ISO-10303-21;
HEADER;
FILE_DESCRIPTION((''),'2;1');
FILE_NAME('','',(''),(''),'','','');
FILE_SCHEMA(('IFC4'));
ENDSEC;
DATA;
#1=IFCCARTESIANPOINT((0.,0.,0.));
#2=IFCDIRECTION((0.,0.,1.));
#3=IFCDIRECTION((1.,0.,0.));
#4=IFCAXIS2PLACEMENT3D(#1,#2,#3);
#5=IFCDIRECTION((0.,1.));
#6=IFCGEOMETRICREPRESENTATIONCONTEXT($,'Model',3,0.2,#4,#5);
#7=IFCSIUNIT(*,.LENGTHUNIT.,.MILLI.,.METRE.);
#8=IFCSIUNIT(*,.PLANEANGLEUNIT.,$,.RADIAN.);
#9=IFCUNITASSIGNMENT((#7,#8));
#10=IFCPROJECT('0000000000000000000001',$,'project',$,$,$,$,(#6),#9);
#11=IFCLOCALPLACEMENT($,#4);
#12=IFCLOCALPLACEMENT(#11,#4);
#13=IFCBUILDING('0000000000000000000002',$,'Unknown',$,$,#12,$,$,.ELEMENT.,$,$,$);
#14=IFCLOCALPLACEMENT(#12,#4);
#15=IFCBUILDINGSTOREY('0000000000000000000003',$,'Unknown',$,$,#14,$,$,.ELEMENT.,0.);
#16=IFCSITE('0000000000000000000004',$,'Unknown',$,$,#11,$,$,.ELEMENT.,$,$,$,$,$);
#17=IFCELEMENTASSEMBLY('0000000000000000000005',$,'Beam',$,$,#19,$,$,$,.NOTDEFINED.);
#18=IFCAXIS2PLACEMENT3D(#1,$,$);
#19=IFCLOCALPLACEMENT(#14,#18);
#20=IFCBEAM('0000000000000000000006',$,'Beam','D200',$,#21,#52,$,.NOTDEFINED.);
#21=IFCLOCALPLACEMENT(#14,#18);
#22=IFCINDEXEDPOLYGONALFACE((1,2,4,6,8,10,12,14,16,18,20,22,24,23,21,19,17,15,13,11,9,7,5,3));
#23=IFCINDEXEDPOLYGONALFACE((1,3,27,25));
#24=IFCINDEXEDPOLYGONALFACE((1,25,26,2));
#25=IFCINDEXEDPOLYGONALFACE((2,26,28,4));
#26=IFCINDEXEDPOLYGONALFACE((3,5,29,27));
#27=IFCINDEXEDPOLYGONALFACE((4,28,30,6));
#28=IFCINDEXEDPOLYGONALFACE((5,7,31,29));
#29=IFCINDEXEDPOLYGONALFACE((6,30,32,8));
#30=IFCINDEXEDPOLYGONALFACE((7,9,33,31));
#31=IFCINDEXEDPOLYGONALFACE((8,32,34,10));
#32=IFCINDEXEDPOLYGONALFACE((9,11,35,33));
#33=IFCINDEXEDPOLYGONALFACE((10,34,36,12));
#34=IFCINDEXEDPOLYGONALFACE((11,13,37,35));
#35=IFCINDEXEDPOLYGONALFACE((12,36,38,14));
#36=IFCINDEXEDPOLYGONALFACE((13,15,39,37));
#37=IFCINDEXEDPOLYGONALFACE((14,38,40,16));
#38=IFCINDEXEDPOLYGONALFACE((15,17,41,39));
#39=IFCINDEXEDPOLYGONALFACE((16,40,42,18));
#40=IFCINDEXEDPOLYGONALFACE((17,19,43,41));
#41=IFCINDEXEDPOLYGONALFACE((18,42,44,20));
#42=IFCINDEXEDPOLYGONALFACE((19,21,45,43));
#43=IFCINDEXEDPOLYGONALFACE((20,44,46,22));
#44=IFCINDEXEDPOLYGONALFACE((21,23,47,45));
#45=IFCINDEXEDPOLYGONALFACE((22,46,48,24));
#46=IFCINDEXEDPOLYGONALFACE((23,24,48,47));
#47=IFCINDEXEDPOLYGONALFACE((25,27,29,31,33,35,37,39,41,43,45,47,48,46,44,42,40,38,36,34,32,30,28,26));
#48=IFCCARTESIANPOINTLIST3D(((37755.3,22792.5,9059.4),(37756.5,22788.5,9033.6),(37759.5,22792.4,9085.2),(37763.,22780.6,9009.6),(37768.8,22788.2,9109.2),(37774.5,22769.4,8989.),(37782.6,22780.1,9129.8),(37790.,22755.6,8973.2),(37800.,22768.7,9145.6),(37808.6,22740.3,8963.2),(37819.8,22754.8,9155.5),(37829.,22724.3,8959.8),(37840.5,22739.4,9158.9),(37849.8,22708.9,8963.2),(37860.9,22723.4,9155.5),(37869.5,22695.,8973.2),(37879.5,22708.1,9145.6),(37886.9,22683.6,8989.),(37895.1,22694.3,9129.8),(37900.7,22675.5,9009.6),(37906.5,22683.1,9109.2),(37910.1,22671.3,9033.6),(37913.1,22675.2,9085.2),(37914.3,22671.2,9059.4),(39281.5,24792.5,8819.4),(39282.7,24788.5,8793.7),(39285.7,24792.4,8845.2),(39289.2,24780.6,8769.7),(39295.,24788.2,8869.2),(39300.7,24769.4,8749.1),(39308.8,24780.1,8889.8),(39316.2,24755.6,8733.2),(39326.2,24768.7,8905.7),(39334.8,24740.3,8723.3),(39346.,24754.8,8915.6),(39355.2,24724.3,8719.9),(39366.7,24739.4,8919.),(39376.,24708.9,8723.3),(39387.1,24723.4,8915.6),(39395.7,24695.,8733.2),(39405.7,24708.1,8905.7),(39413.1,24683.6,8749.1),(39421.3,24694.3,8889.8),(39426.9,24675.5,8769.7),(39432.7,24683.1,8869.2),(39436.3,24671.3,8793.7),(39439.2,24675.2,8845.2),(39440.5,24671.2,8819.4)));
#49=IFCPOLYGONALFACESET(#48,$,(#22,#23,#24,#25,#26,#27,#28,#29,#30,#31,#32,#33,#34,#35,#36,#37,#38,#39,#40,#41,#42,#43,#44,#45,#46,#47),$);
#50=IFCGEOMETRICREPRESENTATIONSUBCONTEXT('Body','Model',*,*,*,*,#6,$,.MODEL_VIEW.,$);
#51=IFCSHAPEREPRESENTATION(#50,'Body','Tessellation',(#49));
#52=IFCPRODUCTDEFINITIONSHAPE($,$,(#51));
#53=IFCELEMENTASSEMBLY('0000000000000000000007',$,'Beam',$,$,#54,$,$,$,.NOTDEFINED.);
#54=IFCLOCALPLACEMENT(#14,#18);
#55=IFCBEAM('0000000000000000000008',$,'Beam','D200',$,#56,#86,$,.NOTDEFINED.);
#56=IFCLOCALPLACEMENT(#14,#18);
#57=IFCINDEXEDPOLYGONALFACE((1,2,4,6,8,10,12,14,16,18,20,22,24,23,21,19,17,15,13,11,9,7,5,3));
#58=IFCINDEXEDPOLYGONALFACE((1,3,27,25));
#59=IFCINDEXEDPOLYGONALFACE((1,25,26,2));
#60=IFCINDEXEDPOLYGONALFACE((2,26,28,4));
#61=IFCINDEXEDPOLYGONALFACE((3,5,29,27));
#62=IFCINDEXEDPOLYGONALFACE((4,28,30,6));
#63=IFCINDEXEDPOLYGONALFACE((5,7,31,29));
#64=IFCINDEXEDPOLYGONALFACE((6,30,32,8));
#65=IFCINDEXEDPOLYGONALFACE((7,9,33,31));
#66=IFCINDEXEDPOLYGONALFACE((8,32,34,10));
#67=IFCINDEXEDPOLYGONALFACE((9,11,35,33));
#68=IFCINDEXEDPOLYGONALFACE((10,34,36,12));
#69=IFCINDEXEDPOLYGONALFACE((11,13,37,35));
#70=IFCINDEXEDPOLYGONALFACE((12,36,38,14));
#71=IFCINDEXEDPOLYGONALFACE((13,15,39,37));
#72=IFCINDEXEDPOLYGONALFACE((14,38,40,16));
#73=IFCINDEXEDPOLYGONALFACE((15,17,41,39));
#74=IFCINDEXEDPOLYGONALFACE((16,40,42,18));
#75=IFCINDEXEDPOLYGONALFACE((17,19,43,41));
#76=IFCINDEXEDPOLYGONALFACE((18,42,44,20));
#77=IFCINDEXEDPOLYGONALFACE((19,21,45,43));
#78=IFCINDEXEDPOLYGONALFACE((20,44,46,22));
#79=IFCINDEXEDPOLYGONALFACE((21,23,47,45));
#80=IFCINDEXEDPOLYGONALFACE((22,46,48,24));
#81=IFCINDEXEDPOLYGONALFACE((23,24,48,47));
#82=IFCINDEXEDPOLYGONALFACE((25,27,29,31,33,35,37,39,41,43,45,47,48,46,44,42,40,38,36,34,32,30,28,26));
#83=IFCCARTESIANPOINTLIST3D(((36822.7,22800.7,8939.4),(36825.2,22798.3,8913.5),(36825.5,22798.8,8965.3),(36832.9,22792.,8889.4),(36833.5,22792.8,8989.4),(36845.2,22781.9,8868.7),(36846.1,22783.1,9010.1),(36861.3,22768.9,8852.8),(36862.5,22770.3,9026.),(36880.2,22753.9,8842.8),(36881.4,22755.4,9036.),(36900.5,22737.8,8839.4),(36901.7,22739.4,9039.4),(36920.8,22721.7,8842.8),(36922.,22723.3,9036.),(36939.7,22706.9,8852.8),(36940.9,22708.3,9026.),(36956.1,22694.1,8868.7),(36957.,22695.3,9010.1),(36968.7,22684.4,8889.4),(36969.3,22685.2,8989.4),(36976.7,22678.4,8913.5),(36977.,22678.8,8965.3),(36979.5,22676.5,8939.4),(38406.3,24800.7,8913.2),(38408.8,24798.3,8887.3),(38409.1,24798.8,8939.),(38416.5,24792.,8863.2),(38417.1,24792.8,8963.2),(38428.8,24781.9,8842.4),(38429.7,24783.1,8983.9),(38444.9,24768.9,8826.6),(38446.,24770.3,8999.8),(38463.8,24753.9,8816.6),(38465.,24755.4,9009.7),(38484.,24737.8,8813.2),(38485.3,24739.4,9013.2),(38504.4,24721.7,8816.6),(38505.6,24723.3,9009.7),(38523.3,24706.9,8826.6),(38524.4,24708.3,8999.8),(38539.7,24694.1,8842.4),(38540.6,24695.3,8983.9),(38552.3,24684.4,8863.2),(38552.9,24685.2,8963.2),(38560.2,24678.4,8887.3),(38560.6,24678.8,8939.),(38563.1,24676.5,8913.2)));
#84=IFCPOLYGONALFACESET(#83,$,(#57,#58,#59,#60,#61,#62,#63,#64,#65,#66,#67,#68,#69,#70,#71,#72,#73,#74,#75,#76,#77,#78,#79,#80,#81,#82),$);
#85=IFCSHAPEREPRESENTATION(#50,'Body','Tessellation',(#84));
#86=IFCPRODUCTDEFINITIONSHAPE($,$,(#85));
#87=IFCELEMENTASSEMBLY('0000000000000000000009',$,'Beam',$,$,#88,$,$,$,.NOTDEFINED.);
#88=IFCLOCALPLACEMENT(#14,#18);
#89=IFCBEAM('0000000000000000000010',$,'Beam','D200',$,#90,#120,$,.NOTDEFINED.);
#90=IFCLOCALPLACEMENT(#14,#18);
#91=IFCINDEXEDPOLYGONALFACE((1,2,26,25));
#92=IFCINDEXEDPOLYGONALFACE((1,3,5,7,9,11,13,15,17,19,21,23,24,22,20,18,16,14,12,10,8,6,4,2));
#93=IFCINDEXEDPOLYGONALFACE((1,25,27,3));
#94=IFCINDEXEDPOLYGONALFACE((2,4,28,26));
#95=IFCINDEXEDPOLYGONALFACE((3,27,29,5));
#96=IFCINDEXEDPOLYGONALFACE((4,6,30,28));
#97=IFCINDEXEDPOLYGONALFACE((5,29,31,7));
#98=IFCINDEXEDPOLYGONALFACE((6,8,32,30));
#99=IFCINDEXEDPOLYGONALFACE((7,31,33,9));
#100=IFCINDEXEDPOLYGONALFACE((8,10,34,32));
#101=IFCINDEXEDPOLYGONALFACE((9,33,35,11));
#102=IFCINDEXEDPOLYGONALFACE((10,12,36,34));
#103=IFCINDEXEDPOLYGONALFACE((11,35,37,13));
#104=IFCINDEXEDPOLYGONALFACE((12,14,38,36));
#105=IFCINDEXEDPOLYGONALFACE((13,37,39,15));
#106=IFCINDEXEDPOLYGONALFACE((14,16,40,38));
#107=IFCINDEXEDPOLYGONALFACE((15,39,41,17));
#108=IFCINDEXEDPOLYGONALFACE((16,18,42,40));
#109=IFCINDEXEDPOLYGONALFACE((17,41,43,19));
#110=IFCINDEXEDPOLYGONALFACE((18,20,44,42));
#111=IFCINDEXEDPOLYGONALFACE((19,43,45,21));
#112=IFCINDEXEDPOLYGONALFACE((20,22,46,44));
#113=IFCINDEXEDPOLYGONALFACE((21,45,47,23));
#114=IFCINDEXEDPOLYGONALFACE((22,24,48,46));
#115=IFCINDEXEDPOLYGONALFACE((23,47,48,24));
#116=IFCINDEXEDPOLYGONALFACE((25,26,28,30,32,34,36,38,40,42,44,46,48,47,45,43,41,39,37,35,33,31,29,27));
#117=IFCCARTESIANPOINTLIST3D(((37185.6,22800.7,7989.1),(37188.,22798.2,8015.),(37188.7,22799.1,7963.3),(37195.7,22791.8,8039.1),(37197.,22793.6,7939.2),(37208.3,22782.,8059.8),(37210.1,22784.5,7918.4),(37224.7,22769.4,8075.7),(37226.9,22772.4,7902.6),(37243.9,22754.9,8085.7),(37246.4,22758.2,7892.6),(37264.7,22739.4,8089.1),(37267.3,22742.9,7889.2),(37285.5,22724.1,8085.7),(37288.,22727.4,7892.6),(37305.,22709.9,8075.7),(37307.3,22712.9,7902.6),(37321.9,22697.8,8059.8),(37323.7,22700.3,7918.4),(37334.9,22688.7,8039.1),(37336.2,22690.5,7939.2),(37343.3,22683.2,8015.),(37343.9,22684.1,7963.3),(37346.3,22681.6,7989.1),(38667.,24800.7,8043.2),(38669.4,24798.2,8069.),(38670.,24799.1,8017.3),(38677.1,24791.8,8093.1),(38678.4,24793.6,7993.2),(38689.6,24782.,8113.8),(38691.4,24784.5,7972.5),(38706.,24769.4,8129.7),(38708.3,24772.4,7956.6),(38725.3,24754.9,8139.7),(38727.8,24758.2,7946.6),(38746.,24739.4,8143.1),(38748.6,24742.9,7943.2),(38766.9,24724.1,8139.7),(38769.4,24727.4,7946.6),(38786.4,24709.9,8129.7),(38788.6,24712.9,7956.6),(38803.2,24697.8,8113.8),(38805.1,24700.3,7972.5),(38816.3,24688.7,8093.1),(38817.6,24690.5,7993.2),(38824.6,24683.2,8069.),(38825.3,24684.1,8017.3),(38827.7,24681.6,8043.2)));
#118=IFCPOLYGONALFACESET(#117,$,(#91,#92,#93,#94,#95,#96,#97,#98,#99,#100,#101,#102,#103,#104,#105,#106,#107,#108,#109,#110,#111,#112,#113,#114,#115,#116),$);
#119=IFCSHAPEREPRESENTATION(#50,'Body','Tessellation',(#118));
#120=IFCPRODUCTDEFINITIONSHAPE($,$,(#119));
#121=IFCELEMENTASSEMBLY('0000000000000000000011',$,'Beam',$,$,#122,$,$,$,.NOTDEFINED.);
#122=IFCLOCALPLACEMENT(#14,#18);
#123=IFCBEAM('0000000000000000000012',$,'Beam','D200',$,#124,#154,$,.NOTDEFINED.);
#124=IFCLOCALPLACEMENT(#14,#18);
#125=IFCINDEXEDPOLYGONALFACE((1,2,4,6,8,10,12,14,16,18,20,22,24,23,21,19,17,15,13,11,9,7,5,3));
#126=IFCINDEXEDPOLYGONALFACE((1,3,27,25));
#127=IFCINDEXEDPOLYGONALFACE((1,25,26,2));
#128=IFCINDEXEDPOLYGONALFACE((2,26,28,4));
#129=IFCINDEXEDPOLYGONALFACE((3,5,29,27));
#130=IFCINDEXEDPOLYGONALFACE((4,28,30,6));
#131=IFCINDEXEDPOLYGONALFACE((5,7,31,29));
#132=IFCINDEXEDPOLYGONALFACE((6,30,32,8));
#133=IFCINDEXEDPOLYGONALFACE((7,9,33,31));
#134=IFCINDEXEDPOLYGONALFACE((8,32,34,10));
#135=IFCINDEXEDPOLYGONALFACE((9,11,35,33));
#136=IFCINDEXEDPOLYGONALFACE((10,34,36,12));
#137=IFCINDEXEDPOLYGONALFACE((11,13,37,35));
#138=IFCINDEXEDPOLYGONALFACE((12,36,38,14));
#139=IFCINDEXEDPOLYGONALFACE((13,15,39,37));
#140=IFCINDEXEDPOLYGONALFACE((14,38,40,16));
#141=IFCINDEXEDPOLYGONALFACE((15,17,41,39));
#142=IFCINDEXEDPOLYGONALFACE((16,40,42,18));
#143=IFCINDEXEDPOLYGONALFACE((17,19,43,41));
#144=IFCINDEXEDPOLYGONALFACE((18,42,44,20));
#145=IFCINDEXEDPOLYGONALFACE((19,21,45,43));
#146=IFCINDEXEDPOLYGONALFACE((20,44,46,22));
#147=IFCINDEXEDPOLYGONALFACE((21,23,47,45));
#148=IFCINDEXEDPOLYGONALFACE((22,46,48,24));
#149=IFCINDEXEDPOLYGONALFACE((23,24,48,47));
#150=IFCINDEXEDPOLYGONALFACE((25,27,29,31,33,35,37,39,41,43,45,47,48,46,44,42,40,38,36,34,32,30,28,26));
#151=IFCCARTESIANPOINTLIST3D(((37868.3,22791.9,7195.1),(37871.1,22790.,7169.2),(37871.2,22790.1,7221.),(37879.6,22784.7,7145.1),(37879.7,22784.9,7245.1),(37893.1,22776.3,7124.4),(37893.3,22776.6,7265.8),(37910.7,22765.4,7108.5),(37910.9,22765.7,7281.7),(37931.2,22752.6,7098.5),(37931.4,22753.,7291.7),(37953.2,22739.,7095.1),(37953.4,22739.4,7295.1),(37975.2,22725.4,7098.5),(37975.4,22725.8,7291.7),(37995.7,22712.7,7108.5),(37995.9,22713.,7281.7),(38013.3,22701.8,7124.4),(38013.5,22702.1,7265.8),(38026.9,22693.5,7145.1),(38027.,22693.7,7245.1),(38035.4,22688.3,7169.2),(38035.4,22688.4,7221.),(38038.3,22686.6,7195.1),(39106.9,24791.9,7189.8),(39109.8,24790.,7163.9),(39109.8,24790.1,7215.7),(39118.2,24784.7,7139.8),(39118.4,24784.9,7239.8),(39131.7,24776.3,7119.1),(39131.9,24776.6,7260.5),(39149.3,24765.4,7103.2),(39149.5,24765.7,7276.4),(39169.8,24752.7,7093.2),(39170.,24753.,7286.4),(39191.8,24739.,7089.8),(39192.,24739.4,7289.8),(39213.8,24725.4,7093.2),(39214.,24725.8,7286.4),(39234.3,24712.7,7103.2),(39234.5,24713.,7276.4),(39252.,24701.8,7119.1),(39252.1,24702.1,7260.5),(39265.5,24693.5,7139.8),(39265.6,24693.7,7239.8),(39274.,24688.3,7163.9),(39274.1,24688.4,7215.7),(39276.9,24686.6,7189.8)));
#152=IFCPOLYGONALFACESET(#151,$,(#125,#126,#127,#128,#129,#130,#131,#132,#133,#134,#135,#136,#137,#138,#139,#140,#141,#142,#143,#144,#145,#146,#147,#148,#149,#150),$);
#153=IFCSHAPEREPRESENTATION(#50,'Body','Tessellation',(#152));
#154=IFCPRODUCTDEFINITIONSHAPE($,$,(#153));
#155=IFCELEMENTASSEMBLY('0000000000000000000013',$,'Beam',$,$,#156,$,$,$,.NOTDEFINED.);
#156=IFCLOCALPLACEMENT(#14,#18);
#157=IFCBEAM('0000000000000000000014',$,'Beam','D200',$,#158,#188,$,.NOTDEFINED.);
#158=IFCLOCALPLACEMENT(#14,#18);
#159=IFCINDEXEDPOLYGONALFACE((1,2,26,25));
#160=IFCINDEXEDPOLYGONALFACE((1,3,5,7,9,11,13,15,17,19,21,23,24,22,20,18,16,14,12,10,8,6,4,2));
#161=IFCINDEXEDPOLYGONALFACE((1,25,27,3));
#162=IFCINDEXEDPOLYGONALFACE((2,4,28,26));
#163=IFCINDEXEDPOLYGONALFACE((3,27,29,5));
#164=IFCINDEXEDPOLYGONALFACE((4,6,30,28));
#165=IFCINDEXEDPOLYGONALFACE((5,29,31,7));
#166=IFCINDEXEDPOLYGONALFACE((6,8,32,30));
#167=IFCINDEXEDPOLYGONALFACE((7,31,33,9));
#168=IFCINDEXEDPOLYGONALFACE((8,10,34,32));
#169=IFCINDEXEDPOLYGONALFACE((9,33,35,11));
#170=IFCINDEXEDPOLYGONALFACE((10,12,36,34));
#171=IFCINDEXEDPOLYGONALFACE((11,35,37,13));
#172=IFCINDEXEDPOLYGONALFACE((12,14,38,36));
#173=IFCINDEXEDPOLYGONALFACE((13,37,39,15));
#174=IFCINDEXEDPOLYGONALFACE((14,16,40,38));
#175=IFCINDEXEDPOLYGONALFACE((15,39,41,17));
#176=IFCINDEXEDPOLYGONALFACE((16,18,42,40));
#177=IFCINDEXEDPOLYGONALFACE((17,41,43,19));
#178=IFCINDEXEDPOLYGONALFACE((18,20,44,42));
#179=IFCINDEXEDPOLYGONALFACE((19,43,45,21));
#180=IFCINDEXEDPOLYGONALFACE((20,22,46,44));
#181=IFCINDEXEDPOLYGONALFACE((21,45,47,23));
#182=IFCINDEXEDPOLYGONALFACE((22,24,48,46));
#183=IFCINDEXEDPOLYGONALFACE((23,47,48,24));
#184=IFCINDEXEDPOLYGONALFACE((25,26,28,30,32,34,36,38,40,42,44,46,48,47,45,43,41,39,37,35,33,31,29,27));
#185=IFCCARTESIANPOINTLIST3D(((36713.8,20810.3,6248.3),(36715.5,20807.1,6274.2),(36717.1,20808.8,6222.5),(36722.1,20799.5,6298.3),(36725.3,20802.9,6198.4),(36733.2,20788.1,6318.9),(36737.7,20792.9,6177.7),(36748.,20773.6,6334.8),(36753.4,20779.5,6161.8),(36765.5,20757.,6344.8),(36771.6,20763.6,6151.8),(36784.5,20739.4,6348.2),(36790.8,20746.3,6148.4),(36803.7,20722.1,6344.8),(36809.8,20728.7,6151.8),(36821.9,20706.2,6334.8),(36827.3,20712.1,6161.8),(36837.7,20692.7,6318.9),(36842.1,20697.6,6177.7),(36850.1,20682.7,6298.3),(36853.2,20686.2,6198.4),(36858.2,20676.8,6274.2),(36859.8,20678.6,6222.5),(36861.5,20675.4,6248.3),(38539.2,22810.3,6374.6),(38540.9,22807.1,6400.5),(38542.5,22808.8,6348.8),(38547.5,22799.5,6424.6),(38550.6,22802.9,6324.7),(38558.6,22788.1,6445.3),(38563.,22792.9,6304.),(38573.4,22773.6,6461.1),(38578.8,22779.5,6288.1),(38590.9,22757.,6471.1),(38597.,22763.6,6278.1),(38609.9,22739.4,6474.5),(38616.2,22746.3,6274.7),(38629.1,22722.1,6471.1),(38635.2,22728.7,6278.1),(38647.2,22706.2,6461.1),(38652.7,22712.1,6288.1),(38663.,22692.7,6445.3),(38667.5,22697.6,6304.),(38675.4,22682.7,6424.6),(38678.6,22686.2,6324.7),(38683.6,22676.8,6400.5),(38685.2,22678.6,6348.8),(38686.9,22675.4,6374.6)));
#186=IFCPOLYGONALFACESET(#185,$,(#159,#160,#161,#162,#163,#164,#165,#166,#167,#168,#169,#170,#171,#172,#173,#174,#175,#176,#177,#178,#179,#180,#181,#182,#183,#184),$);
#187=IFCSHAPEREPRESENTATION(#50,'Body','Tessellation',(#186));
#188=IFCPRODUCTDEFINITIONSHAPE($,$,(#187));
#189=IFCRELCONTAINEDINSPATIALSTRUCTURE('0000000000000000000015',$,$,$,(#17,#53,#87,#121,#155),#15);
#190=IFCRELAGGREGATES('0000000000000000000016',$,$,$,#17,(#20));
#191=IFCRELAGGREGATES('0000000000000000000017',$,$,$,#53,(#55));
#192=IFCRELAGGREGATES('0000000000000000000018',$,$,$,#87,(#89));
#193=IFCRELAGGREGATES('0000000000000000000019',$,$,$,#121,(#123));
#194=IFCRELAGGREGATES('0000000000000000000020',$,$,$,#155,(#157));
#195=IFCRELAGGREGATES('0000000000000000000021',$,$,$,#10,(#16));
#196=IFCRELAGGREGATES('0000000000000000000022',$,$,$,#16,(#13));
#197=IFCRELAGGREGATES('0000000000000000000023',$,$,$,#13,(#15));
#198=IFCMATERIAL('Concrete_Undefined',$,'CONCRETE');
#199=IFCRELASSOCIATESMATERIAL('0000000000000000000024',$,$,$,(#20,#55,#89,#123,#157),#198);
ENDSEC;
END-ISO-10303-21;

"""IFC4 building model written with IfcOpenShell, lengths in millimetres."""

from ifc_helpers import new_model, si_unit, direction, frame, origin_with_axes, place, context, subcontext, project, spatial, line, indexed_curve, outline, extrude, material, element, aggregate, save


model = new_model("IFC4")

# Units and contexts
model_context = context("Model", 3, precision=0.2, world=origin_with_axes(), true_north=direction((0.0, 1.0)))
body_context = subcontext(model_context, "Body", "Model", "MODEL_VIEW")
ifc_project = project(units=[si_unit("LENGTHUNIT", "METRE", prefix="MILLI"), si_unit("PLANEANGLEUNIT", "RADIAN")], contexts=[model_context])

# Site, building, storey
site_placement = place(None, origin_with_axes())
site = spatial("IfcSite", under=ifc_project, at=site_placement, Name="Unknown", CompositionType="ELEMENT")
building_placement = place(site_placement, origin_with_axes())
building = spatial("IfcBuilding", under=site, at=building_placement, Name="Unknown", CompositionType="ELEMENT")
storey_placement = place(building_placement, origin_with_axes())
storey = spatial("IfcBuildingStorey", under=building, at=storey_placement, Name="Unknown", CompositionType="ELEMENT", Elevation=0.0)

# Element assemblies, beams
ifc_material = material(Name="Concrete_Undefined", Category="CONCRETE")
assembly_1_placement = place(storey_placement, frame((39361.0, 24731.9, 8819.4), z_axis=(-0.794975, 0.606643, 0.0), x_axis=(-0.603902, -0.791384, 0.094942)))
assembly_1 = element("IfcElementAssembly", 1, at=assembly_1_placement, inside=storey, Name="Beam", PredefinedType="NOTDEFINED")
beam_1_placement = place(assembly_1_placement, origin_with_axes())
beam_1 = element("IfcBeam", 2, at=beam_1_placement, material=ifc_material, Name="Beam", Description="D200", PredefinedType="NOTDEFINED", context=body_context, shape_type="SolidModel", body=[
    extrude(outline(indexed_curve([(100.0, 0.0), (96.6, 25.9), (86.6, 50.0), (70.7, 70.7), (50.0, 86.6), (25.9, 96.6), (0.0, 100.0), (-25.9, 96.6), (-50.0, 86.6), (-70.7, 70.7), (-86.6, 50.0), (-96.6, 25.9), (-100.0, 0.0), (-96.6, -25.9), (-86.6, -50.0), (-70.7, -70.7), (-50.0, -86.6), (-25.9, -96.6), (0.0, -100.0), (25.9, -96.6), (50.0, -86.6), (70.7, -70.7), (86.6, -50.0), (96.6, -25.9)], segments=[line(1, 2, 3, 4, 5, 6, 7, 8, 9, 10, 11, 12, 13, 14, 15, 16, 17, 18, 19, 20, 21, 22, 23, 24, 1)])), frame((0.0, 0.0, 0.0), z_axis=(-1.0, 0.0, 0.0), x_axis=(0.0, 0.0, 1.0)), (0.0, 0.0, -1.0), 2527.2),
])
aggregate(assembly_1, [beam_1])
assembly_2_placement = place(storey_placement, frame((38484.7, 24738.6, 8913.2), z_axis=(-0.783999, 0.620762, 0.0), x_axis=(-0.620729, -0.783958, 0.010288)))
assembly_2 = element("IfcElementAssembly", 3, at=assembly_2_placement, inside=storey, Name="Beam", PredefinedType="NOTDEFINED")
beam_2_placement = place(assembly_2_placement, origin_with_axes())
beam_2 = element("IfcBeam", 4, at=beam_2_placement, material=ifc_material, Name="Beam", Description="D200", PredefinedType="NOTDEFINED", context=body_context, shape_type="SolidModel", body=[
    extrude(outline(indexed_curve([(100.0, 0.0), (96.6, 25.9), (86.6, 50.0), (70.7, 70.7), (50.0, 86.6), (25.9, 96.6), (0.0, 100.0), (-25.9, 96.6), (-50.0, 86.6), (-70.7, 70.7), (-86.6, 50.0), (-96.6, 25.9), (-100.0, 0.0), (-96.6, -25.9), (-86.6, -50.0), (-70.7, -70.7), (-50.0, -86.6), (-25.9, -96.6), (0.0, -100.0), (25.9, -96.6), (50.0, -86.6), (70.7, -70.7), (86.6, -50.0), (96.6, -25.9)], segments=[line(1, 2, 3, 4, 5, 6, 7, 8, 9, 10, 11, 12, 13, 14, 15, 16, 17, 18, 19, 20, 21, 22, 23, 24, 1)])), frame((0.0, 0.0, 0.0), z_axis=(-1.0, 0.0, 0.0), x_axis=(0.0, 0.0, 1.0)), (0.0, 0.0, -1.0), 2551.2),
])
aggregate(assembly_2, [beam_2])
assembly_3_placement = place(storey_placement, frame((38747.3, 24741.1, 8043.2), z_axis=(-0.803586, 0.595188, 0.0), x_axis=(-0.595048, -0.803397, -0.021698)))
assembly_3 = element("IfcElementAssembly", 5, at=assembly_3_placement, inside=storey, Name="Beam", PredefinedType="NOTDEFINED")
beam_3_placement = place(assembly_3_placement, origin_with_axes())
beam_3 = element("IfcBeam", 6, at=beam_3_placement, material=ifc_material, Name="Beam", Description="D200", PredefinedType="NOTDEFINED", context=body_context, shape_type="SolidModel", body=[
    extrude(outline(indexed_curve([(100.0, 0.0), (96.6, 25.9), (86.6, 50.0), (70.7, 70.7), (50.0, 86.6), (25.9, 96.6), (0.0, 100.0), (-25.9, 96.6), (-50.0, 86.6), (-70.7, 70.7), (-86.6, 50.0), (-96.6, 25.9), (-100.0, 0.0), (-96.6, -25.9), (-86.6, -50.0), (-70.7, -70.7), (-50.0, -86.6), (-25.9, -96.6), (0.0, -100.0), (25.9, -96.6), (50.0, -86.6), (70.7, -70.7), (86.6, -50.0), (96.6, -25.9)], segments=[line(1, 2, 3, 4, 5, 6, 7, 8, 9, 10, 11, 12, 13, 14, 15, 16, 17, 18, 19, 20, 21, 22, 23, 24, 1)])), frame((0.0, 0.0, 0.0), z_axis=(-1.0, 0.0, 0.0), x_axis=(0.0, 0.0, 1.0)), (0.0, 0.0, -1.0), 2489.4),
])
aggregate(assembly_3, [beam_3])
assembly_4_placement = place(storey_placement, frame((39191.9, 24739.2, 7189.8), z_axis=(-0.850163, 0.526519, 0.0), x_axis=(-0.526518, -0.850161, 0.002261)))
assembly_4 = element("IfcElementAssembly", 7, at=assembly_4_placement, inside=storey, Name="Beam", PredefinedType="NOTDEFINED")
beam_4_placement = place(assembly_4_placement, origin_with_axes())
beam_4 = element("IfcBeam", 8, at=beam_4_placement, material=ifc_material, Name="Beam", Description="D200", PredefinedType="NOTDEFINED", context=body_context, shape_type="SolidModel", body=[
    extrude(outline(indexed_curve([(100.0, 0.0), (96.6, 25.9), (86.6, 50.0), (70.7, 70.7), (50.0, 86.6), (25.9, 96.6), (0.0, 100.0), (-25.9, 96.6), (-50.0, 86.6), (-70.7, 70.7), (-86.6, 50.0), (-96.6, 25.9), (-100.0, 0.0), (-96.6, -25.9), (-86.6, -50.0), (-70.7, -70.7), (-50.0, -86.6), (-25.9, -96.6), (0.0, -100.0), (25.9, -96.6), (50.0, -86.6), (70.7, -70.7), (86.6, -50.0), (96.6, -25.9)], segments=[line(1, 2, 3, 4, 5, 6, 7, 8, 9, 10, 11, 12, 13, 14, 15, 16, 17, 18, 19, 20, 21, 22, 23, 24, 1)])), frame((0.0, 0.0, 0.0), z_axis=(-1.0, 0.0, 0.0), x_axis=(0.0, 0.0, 1.0)), (0.0, 0.0, -1.0), 2352.5),
])
aggregate(assembly_4, [beam_4])
assembly_5_placement = place(storey_placement, frame((38613.0, 22742.8, 6374.6), z_axis=(-0.738616, 0.674126, 0.0), x_axis=(-0.673394, -0.737814, -0.046601)))
assembly_5 = element("IfcElementAssembly", 9, at=assembly_5_placement, inside=storey, Name="Beam", PredefinedType="NOTDEFINED")
beam_5_placement = place(assembly_5_placement, origin_with_axes())
beam_5 = element("IfcBeam", 10, at=beam_5_placement, material=ifc_material, Name="Beam", Description="D200", PredefinedType="NOTDEFINED", context=body_context, shape_type="SolidModel", body=[
    extrude(outline(indexed_curve([(100.0, 0.0), (96.6, 25.9), (86.6, 50.0), (70.7, 70.7), (50.0, 86.6), (25.9, 96.6), (0.0, 100.0), (-25.9, 96.6), (-50.0, 86.6), (-70.7, 70.7), (-86.6, 50.0), (-96.6, 25.9), (-100.0, 0.0), (-96.6, -25.9), (-86.6, -50.0), (-70.7, -70.7), (-50.0, -86.6), (-25.9, -96.6), (0.0, -100.0), (25.9, -96.6), (50.0, -86.6), (70.7, -70.7), (86.6, -50.0), (96.6, -25.9)], segments=[line(1, 2, 3, 4, 5, 6, 7, 8, 9, 10, 11, 12, 13, 14, 15, 16, 17, 18, 19, 20, 21, 22, 23, 24, 1)])), frame((0.0, 0.0, 0.0), z_axis=(-1.0, 0.0, 0.0), x_axis=(0.0, 0.0, 1.0)), (0.0, 0.0, -1.0), 2710.7),
])
aggregate(assembly_5, [beam_5])

save(model, "model.ifc")
